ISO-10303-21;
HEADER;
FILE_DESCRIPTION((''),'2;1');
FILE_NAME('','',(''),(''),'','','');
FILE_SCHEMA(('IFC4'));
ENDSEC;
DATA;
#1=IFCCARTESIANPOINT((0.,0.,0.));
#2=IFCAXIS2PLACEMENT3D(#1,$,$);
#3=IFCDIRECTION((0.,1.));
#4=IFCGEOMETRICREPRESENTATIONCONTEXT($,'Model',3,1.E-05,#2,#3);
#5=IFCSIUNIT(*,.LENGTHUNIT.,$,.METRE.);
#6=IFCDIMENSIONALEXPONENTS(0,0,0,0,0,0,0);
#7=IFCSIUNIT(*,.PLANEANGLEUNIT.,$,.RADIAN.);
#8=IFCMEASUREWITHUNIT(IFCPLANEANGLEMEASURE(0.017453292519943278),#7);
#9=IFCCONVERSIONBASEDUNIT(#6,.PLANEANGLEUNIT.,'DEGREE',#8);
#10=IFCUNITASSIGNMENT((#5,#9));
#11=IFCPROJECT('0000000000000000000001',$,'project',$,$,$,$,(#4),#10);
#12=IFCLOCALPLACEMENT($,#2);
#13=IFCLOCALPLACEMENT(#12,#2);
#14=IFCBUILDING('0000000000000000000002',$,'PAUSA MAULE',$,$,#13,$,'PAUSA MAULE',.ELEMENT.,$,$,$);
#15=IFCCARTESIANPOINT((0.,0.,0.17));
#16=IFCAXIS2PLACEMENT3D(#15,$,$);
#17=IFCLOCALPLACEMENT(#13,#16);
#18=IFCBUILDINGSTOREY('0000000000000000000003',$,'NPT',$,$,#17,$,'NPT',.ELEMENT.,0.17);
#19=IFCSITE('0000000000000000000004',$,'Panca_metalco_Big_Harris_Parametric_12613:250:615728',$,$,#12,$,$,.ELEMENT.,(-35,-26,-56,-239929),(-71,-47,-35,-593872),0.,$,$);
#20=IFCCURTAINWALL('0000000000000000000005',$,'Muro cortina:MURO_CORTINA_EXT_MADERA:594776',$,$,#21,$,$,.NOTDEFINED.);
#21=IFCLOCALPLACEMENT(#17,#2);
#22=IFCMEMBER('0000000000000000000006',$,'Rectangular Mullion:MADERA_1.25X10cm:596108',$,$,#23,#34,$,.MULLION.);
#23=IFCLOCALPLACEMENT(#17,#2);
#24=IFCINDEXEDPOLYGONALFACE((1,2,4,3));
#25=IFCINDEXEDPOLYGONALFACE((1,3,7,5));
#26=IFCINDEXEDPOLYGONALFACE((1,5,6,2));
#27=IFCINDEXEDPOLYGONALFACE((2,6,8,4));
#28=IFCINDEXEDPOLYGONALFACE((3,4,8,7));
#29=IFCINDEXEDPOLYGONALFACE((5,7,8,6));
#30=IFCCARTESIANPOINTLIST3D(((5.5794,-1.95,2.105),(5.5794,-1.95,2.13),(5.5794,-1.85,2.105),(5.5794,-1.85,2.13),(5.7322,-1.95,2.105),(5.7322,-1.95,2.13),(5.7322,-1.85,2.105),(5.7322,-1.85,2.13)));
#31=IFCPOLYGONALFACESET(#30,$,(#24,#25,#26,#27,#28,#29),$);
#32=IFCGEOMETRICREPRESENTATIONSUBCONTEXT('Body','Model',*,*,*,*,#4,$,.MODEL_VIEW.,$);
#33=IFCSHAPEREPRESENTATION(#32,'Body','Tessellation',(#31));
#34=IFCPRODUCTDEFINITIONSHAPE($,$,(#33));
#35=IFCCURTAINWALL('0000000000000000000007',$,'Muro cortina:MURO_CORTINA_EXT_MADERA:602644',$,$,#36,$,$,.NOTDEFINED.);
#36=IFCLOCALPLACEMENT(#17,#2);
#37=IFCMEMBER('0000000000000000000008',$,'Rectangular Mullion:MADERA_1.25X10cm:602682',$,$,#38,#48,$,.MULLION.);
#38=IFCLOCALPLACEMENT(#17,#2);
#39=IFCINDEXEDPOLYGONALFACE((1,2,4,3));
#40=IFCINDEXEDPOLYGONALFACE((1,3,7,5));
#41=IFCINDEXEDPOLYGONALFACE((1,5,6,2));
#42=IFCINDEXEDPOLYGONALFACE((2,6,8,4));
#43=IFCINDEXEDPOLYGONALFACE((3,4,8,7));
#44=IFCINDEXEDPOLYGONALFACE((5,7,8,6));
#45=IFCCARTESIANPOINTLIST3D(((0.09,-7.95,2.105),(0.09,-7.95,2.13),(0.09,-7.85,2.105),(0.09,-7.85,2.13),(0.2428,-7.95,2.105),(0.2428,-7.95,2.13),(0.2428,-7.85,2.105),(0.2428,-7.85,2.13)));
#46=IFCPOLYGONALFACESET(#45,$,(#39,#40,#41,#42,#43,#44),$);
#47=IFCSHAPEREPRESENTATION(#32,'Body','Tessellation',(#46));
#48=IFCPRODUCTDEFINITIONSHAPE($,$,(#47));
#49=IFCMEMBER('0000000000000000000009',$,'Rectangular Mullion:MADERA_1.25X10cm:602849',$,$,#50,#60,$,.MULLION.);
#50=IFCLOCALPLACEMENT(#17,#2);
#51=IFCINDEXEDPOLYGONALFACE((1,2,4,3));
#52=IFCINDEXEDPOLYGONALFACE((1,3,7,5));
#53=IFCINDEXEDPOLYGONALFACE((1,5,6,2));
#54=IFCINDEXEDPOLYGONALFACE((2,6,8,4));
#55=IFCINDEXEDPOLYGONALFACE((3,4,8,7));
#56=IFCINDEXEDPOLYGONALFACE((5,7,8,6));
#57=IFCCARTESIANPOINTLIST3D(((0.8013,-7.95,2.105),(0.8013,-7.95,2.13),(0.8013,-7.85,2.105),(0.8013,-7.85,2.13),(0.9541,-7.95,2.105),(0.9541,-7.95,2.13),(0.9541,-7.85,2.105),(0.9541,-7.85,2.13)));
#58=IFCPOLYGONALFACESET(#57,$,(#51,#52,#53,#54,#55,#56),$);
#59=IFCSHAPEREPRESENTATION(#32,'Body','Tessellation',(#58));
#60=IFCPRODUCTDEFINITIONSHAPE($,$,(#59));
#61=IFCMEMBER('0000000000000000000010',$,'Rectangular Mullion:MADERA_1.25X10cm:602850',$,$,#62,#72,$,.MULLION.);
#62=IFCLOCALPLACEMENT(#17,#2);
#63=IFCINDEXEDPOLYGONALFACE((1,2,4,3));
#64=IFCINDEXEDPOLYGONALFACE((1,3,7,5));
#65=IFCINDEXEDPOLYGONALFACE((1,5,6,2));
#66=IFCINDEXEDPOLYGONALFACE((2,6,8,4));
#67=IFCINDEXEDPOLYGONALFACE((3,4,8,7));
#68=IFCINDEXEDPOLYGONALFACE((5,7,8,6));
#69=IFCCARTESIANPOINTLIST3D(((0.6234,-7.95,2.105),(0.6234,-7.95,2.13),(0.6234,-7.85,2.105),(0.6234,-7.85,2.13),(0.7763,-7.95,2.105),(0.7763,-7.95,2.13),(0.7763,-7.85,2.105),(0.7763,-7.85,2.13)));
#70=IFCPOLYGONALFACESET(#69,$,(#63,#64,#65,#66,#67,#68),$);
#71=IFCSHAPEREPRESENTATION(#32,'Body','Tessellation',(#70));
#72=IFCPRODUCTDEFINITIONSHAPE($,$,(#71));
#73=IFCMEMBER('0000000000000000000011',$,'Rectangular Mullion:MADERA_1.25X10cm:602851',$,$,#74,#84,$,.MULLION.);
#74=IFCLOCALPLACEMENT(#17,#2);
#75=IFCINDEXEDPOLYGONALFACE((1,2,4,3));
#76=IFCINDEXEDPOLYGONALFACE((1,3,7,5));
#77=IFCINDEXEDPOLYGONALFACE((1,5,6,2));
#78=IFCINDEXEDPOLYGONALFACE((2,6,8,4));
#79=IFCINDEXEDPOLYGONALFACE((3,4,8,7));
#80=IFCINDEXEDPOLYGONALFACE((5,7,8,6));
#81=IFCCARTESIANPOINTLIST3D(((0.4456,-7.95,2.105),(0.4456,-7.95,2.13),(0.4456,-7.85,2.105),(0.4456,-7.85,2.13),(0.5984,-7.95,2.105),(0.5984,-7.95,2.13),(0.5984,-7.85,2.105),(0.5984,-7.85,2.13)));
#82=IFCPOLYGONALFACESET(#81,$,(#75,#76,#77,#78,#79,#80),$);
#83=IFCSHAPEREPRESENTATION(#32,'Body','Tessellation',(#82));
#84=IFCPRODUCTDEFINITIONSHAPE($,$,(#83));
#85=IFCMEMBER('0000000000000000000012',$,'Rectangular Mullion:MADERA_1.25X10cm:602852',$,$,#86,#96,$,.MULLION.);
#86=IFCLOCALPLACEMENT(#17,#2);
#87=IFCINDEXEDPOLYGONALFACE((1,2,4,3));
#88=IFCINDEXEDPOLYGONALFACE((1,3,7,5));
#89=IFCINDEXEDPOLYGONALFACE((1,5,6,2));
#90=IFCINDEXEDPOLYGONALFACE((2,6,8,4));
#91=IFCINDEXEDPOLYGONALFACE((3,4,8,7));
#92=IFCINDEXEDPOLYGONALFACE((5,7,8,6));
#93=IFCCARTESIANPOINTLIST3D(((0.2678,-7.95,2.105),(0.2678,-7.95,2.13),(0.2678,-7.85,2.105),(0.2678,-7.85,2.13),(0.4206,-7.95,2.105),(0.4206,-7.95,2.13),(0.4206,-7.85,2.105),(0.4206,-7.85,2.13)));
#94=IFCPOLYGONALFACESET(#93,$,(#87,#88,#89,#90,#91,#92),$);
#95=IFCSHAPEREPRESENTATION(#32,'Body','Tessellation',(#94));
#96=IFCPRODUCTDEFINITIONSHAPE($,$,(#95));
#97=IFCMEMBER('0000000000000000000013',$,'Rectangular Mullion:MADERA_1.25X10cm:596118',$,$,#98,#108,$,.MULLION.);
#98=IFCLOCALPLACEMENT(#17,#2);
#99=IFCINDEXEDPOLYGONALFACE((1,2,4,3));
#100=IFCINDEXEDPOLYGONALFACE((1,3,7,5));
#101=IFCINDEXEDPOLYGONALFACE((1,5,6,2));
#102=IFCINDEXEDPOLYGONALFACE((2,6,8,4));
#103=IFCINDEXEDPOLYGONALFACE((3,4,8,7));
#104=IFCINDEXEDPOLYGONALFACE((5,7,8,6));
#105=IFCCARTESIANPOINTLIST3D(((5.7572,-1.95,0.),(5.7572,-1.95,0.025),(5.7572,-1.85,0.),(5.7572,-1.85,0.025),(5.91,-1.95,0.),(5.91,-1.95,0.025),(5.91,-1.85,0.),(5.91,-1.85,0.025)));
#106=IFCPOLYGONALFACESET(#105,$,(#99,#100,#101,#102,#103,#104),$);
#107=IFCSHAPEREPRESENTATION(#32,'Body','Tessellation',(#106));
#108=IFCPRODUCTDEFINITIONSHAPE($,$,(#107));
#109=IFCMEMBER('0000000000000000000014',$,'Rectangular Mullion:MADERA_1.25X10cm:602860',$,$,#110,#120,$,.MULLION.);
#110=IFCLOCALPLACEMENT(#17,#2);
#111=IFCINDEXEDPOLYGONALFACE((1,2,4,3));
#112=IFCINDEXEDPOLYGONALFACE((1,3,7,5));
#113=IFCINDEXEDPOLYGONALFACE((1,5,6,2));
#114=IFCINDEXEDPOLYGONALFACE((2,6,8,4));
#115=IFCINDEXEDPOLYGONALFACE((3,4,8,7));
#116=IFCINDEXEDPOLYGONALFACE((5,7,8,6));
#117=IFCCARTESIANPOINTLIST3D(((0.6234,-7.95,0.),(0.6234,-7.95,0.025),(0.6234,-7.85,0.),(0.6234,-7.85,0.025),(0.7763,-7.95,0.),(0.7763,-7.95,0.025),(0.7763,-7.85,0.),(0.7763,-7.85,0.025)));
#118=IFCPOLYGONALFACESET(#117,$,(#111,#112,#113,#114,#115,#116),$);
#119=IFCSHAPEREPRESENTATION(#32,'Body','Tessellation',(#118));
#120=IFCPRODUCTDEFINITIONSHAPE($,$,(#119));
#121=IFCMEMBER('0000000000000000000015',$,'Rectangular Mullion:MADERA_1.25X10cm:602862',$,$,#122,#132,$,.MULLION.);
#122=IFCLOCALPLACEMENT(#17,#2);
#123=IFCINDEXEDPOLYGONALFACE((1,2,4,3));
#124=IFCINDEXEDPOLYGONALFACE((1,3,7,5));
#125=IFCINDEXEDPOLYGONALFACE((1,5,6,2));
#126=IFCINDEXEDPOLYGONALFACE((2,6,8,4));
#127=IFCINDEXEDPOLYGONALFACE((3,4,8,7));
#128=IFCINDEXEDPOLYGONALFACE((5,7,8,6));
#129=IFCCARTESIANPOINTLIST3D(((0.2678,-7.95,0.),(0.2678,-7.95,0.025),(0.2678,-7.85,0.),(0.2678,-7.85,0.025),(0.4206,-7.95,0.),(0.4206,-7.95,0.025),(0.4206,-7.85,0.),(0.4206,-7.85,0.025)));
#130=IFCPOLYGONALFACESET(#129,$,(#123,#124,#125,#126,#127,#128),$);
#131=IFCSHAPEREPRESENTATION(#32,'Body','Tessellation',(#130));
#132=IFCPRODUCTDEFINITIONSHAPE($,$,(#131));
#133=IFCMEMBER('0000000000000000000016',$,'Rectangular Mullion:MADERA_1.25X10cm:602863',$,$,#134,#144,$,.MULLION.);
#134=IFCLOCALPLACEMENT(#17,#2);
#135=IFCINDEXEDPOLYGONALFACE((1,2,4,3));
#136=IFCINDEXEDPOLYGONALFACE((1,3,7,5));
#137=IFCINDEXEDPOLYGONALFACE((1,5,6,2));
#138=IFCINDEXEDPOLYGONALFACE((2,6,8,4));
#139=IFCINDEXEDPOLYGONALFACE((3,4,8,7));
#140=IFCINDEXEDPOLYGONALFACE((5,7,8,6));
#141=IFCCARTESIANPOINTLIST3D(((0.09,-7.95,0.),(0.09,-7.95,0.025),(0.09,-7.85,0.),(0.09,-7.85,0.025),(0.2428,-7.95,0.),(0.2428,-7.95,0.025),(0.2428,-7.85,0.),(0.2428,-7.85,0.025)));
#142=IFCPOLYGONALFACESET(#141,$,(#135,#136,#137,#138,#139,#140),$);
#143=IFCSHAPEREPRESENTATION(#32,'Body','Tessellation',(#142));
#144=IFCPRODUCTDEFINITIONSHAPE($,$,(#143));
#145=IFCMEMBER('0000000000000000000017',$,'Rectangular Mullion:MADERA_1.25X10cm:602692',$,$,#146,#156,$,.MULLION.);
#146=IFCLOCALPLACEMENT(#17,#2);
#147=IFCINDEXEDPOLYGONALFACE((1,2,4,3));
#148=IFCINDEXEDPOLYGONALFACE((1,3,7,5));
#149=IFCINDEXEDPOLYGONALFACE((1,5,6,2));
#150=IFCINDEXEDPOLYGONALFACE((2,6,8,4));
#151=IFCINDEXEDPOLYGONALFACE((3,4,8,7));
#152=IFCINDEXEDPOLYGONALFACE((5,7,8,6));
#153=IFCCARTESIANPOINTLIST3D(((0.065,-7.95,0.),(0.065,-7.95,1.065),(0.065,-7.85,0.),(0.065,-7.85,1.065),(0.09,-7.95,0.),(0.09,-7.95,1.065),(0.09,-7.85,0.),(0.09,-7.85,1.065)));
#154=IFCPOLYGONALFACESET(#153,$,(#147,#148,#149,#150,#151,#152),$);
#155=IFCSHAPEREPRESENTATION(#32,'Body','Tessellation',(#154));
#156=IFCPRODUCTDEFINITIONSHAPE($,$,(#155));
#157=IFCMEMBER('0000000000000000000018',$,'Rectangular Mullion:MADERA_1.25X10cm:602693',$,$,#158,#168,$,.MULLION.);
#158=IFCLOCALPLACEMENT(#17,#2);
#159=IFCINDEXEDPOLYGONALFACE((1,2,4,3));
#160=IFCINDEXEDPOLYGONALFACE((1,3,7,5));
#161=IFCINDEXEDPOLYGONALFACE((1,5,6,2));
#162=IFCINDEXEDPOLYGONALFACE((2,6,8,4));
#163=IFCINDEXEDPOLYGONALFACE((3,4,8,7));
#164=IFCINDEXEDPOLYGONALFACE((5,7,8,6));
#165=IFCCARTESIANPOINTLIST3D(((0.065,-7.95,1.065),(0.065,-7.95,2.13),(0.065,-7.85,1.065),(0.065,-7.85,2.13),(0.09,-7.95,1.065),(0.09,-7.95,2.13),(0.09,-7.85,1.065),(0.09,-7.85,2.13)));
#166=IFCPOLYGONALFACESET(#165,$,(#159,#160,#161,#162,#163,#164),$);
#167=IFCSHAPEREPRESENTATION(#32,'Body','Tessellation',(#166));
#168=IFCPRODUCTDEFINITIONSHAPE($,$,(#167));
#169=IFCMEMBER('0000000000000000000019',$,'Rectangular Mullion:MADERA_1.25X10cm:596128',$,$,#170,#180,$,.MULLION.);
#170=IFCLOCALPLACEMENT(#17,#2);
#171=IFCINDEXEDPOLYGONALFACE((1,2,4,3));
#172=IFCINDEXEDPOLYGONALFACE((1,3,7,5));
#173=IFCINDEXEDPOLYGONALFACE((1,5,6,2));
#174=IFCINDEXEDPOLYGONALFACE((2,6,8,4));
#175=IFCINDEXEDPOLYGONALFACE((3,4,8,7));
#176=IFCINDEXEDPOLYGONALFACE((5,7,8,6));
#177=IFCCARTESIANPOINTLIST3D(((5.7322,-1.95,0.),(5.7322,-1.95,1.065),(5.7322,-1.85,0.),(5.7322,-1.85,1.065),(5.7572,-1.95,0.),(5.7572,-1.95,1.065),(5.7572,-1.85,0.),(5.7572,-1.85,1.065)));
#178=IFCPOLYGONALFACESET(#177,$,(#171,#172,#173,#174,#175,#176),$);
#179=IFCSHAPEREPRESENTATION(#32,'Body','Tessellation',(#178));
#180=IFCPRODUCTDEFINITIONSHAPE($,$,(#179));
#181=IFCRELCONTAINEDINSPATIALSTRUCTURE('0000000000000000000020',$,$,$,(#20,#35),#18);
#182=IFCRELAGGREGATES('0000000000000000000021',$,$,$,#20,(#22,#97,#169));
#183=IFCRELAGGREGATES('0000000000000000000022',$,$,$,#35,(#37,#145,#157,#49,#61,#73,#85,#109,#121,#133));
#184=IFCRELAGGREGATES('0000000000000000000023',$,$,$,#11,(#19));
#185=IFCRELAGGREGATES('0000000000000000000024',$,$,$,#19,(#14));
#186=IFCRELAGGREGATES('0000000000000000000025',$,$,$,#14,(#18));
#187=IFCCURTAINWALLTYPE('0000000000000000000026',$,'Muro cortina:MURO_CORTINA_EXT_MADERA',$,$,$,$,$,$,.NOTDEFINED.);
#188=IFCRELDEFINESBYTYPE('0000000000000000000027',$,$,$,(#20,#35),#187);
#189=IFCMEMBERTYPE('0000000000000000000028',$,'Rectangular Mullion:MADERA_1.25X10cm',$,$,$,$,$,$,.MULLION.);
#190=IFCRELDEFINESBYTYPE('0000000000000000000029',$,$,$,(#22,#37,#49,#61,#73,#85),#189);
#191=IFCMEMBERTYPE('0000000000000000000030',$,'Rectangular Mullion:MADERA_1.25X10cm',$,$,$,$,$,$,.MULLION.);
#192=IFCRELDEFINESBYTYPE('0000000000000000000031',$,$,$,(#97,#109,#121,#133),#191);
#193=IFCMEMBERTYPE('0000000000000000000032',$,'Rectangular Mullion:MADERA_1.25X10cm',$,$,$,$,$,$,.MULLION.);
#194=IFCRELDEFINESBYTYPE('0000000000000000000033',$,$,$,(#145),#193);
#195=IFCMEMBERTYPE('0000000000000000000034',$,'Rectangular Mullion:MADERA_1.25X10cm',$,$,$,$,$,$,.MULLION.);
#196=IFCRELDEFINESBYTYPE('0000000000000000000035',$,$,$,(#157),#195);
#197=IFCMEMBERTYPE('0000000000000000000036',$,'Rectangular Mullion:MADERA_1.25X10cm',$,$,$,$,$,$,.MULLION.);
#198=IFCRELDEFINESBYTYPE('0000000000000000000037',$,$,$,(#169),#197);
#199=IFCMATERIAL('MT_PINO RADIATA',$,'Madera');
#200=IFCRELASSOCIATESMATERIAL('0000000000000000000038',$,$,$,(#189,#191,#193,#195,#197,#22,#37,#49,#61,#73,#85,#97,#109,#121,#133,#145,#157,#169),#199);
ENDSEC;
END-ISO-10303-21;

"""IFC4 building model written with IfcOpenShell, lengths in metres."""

from ifc_helpers import new_model, entity, si_unit, converted_unit, direction, frame, frame_2d, origin, origin_2d_with_axis, place, context, subcontext, project, spatial, rectangle, extrude, source, transform, mapped, material, material_profile, profile_set, profile_usage, type_object, type_shapes, element, aggregate, save


model = new_model("IFC4")

# Units and contexts
model_context = context("Model", 3, precision=1e-05, world=origin(), true_north=direction((0.0, 1.0)))
body_context = subcontext(model_context, "Body", "Model", "MODEL_VIEW")
ifc_project = project(units=[si_unit("LENGTHUNIT", "METRE"), converted_unit("PLANEANGLEUNIT", "DEGREE", entity("IfcPlaneAngleMeasure", 0.017453292519943278), si_unit("PLANEANGLEUNIT", "RADIAN"), dimensions=[0, 0, 0, 0, 0, 0, 0])], contexts=[model_context])

# Site, building, storey
site_placement = place(None, origin())
site = spatial("IfcSite", under=ifc_project, at=site_placement, Name="Panca_metalco_Big_Harris_Parametric_12613:250:615728", CompositionType="ELEMENT", RefLatitude=(-35, -26, -56, -239929), RefLongitude=(-71, -47, -35, -593872), RefElevation=0.0)
building_placement = place(site_placement, origin())
building = spatial("IfcBuilding", under=site, at=building_placement, Name="PAUSA MAULE", LongName="PAUSA MAULE", CompositionType="ELEMENT")
storey_placement = place(building_placement, frame((0.0, 0.0, 0.17)))
storey = spatial("IfcBuildingStorey", under=building, at=storey_placement, Name="NPT", LongName="NPT", CompositionType="ELEMENT", Elevation=0.17)

# Curtain wall, member
curtain_wall_type = type_object("IfcCurtainWallType", Name="Muro cortina:MURO_CORTINA_EXT_MADERA", PredefinedType="NOTDEFINED")
curtain_wall_1_placement = place(storey_placement, frame((0.0, 0.0, -0.17)))
curtain_wall_1 = element("IfcCurtainWall", 1, at=curtain_wall_1_placement, inside=storey, type_object=curtain_wall_type, Name="Muro cortina:MURO_CORTINA_EXT_MADERA:594776", PredefinedType="NOTDEFINED")
ifc_material_1 = material(Name="MT_PINO RADIATA", Category="Madera")
ifc_material_profile = material_profile(ifc_material_1, rectangle(XDim=0.025, YDim=0.1, at=frame_2d((0.0, 0.0), x_axis=(1.0, 0.0))), Name="MADERA_1.25X10cm")
ifc_profile_set = profile_set([ifc_material_profile], Name="MADERA_1.25X10cm")
ifc_profile_usage = profile_usage(ifc_profile_set)
member_type_1 = type_object("IfcMemberType", Name="Rectangular Mullion:MADERA_1.25X10cm", PredefinedType="MULLION", material=ifc_profile_set)
shared_shape_1 = source(origin(), body_context, "Body", "SweptSolid", [
    extrude(rectangle(XDim=0.025, YDim=0.1, at=frame_2d((0.0, 0.0), x_axis=(1.0, 0.0))), frame((-0.0125, 0.0, -0.1528), z_axis=(0.0, 0.0, 1.0), x_axis=(-1.0, 0.0, 0.0)), (0.0, 0.0, 1.0), 0.1528),
])
type_shapes(member_type_1, [shared_shape_1])
member_1_placement = place(curtain_wall_1_placement, frame((5.7322, -1.9, 2.3), z_axis=(1.0, 0.0, 0.0), x_axis=(0.0, 0.0, 1.0)))
member_1 = element("IfcMember", 2, at=member_1_placement, type_object=member_type_1, material=ifc_profile_usage, Name="Rectangular Mullion:MADERA_1.25X10cm:596108", PredefinedType="MULLION", context=body_context, shape_type="MappedRepresentation", body=[
    mapped(shared_shape_1, transform((0.0, 0.0, 0.0), scale=1.0)),
])

# Curtain wall, members
curtain_wall_2_placement = place(storey_placement, frame((0.0, 0.0, -0.17)))
curtain_wall_2 = element("IfcCurtainWall", 3, at=curtain_wall_2_placement, inside=storey, type_object=curtain_wall_type, Name="Muro cortina:MURO_CORTINA_EXT_MADERA:602644", PredefinedType="NOTDEFINED")
member_2_placement = place(curtain_wall_2_placement, frame((0.09, -7.9, 2.3), z_axis=(-1.0, 0.0, 0.0), x_axis=(0.0, 0.0, 1.0)))
member_2 = element("IfcMember", 4, at=member_2_placement, type_object=member_type_1, material=ifc_profile_usage, Name="Rectangular Mullion:MADERA_1.25X10cm:602682", PredefinedType="MULLION", context=body_context, shape_type="MappedRepresentation", body=[
    mapped(shared_shape_1, transform((0.0, 0.0, 0.0), scale=1.0)),
])
member_3_placement = place(curtain_wall_2_placement, frame((0.8013, -7.9, 2.3), z_axis=(-1.0, 0.0, 0.0), x_axis=(0.0, 0.0, 1.0)))
member_3 = element("IfcMember", 5, at=member_3_placement, type_object=member_type_1, material=ifc_profile_usage, Name="Rectangular Mullion:MADERA_1.25X10cm:602849", PredefinedType="MULLION", context=body_context, shape_type="MappedRepresentation", body=[
    mapped(shared_shape_1, transform((0.0, 0.0, 0.0), scale=1.0)),
])
member_4_placement = place(curtain_wall_2_placement, frame((0.6234, -7.9, 2.3), z_axis=(-1.0, 0.0, 0.0), x_axis=(0.0, 0.0, 1.0)))
member_4 = element("IfcMember", 6, at=member_4_placement, type_object=member_type_1, material=ifc_profile_usage, Name="Rectangular Mullion:MADERA_1.25X10cm:602850", PredefinedType="MULLION", context=body_context, shape_type="MappedRepresentation", body=[
    mapped(shared_shape_1, transform((0.0, 0.0, 0.0), scale=1.0)),
])
member_5_placement = place(curtain_wall_2_placement, frame((0.4456, -7.9, 2.3), z_axis=(-1.0, 0.0, 0.0), x_axis=(0.0, 0.0, 1.0)))
member_5 = element("IfcMember", 7, at=member_5_placement, type_object=member_type_1, material=ifc_profile_usage, Name="Rectangular Mullion:MADERA_1.25X10cm:602851", PredefinedType="MULLION", context=body_context, shape_type="MappedRepresentation", body=[
    mapped(shared_shape_1, transform((0.0, 0.0, 0.0), scale=1.0)),
])
member_6_placement = place(curtain_wall_2_placement, frame((0.2678, -7.9, 2.3), z_axis=(-1.0, 0.0, 0.0), x_axis=(0.0, 0.0, 1.0)))
member_6 = element("IfcMember", 8, at=member_6_placement, type_object=member_type_1, material=ifc_profile_usage, Name="Rectangular Mullion:MADERA_1.25X10cm:602852", PredefinedType="MULLION", context=body_context, shape_type="MappedRepresentation", body=[
    mapped(shared_shape_1, transform((0.0, 0.0, 0.0), scale=1.0)),
])

# Members
member_type_2 = type_object("IfcMemberType", Name="Rectangular Mullion:MADERA_1.25X10cm", PredefinedType="MULLION", material=ifc_profile_set)
shared_shape_2 = source(origin(), body_context, "Body", "SweptSolid", [
    extrude(rectangle(XDim=0.025, YDim=0.1, at=frame_2d((0.0, 0.0), x_axis=(1.0, 0.0))), frame((-0.0125, 0.0, -0.1528), z_axis=(0.0, 0.0, 1.0), x_axis=(-1.0, 0.0, 0.0)), (0.0, 0.0, 1.0), 0.1528),
])
type_shapes(member_type_2, [shared_shape_2])
member_7_placement = place(curtain_wall_1_placement, frame((5.7572, -1.9, 0.17), z_axis=(-1.0, 0.0, 0.0), x_axis=(0.0, 0.0, -1.0)))
member_7 = element("IfcMember", 9, at=member_7_placement, type_object=member_type_2, material=ifc_profile_usage, Name="Rectangular Mullion:MADERA_1.25X10cm:596118", PredefinedType="MULLION", context=body_context, shape_type="MappedRepresentation", body=[
    mapped(shared_shape_2, transform((0.0, 0.0, 0.0), scale=1.0)),
])
member_8_placement = place(curtain_wall_2_placement, frame((0.7763, -7.9, 0.17), z_axis=(1.0, 0.0, 0.0), x_axis=(0.0, 0.0, -1.0)))
member_8 = element("IfcMember", 10, at=member_8_placement, type_object=member_type_2, material=ifc_profile_usage, Name="Rectangular Mullion:MADERA_1.25X10cm:602860", PredefinedType="MULLION", context=body_context, shape_type="MappedRepresentation", body=[
    mapped(shared_shape_2, transform((0.0, 0.0, 0.0), scale=1.0)),
])
member_9_placement = place(curtain_wall_2_placement, frame((0.4206, -7.9, 0.17), z_axis=(1.0, 0.0, 0.0), x_axis=(0.0, 0.0, -1.0)))
member_9 = element("IfcMember", 11, at=member_9_placement, type_object=member_type_2, material=ifc_profile_usage, Name="Rectangular Mullion:MADERA_1.25X10cm:602862", PredefinedType="MULLION", context=body_context, shape_type="MappedRepresentation", body=[
    mapped(shared_shape_2, transform((0.0, 0.0, 0.0), scale=1.0)),
])
member_10_placement = place(curtain_wall_2_placement, frame((0.2428, -7.9, 0.17), z_axis=(1.0, 0.0, 0.0), x_axis=(0.0, 0.0, -1.0)))
member_10 = element("IfcMember", 12, at=member_10_placement, type_object=member_type_2, material=ifc_profile_usage, Name="Rectangular Mullion:MADERA_1.25X10cm:602863", PredefinedType="MULLION", context=body_context, shape_type="MappedRepresentation", body=[
    mapped(shared_shape_2, transform((0.0, 0.0, 0.0), scale=1.0)),
])
member_type_3 = type_object("IfcMemberType", Name="Rectangular Mullion:MADERA_1.25X10cm", PredefinedType="MULLION", material=ifc_profile_set)
shared_shape_3 = source(origin(), body_context, "Body", "SweptSolid", [
    extrude(rectangle(XDim=0.025, YDim=0.1, at=origin_2d_with_axis()), frame((-0.0125, 0.0, -1.065), z_axis=(0.0, 0.0, 1.0), x_axis=(-1.0, 0.0, 0.0)), (0.0, 0.0, 1.0), 1.065),
])
type_shapes(member_type_3, [shared_shape_3])
member_11_placement = place(curtain_wall_2_placement, frame((0.065, -7.9, 0.17), z_axis=(0.0, 0.0, -1.0), x_axis=(-1.0, 0.0, 0.0)))
member_11 = element("IfcMember", 13, at=member_11_placement, type_object=member_type_3, material=ifc_profile_usage, Name="Rectangular Mullion:MADERA_1.25X10cm:602692", PredefinedType="MULLION", context=body_context, shape_type="MappedRepresentation", body=[
    mapped(shared_shape_3, transform((0.0, 0.0, 0.0), scale=1.0)),
])
member_type_4 = type_object("IfcMemberType", Name="Rectangular Mullion:MADERA_1.25X10cm", PredefinedType="MULLION", material=ifc_profile_set)
shared_shape_4 = source(origin(), body_context, "Body", "SweptSolid", [
    extrude(rectangle(XDim=0.025, YDim=0.1, at=origin_2d_with_axis()), frame((-0.0125, 0.0, -1.065), z_axis=(0.0, 0.0, 1.0), x_axis=(-1.0, 0.0, 0.0)), (0.0, 0.0, 1.0), 1.065),
])
type_shapes(member_type_4, [shared_shape_4])
member_12_placement = place(curtain_wall_2_placement, frame((0.065, -7.9, 1.235), z_axis=(0.0, 0.0, -1.0), x_axis=(-1.0, 0.0, 0.0)))
member_12 = element("IfcMember", 14, at=member_12_placement, type_object=member_type_4, material=ifc_profile_usage, Name="Rectangular Mullion:MADERA_1.25X10cm:602693", PredefinedType="MULLION", context=body_context, shape_type="MappedRepresentation", body=[
    mapped(shared_shape_4, transform((0.0, 0.0, 0.0), scale=1.0)),
])
member_type_5 = type_object("IfcMemberType", Name="Rectangular Mullion:MADERA_1.25X10cm", PredefinedType="MULLION", material=ifc_profile_set)
shared_shape_5 = source(origin(), body_context, "Body", "SweptSolid", [
    extrude(rectangle(XDim=0.025, YDim=0.1, at=frame_2d((0.0, 0.0), x_axis=(1.0, 0.0))), frame((0.0, 0.0, -1.065), z_axis=(0.0, 0.0, 1.0), x_axis=(-1.0, 0.0, 0.0)), (0.0, 0.0, 1.0), 1.065),
])
type_shapes(member_type_5, [shared_shape_5])
member_13_placement = place(curtain_wall_1_placement, frame((5.7447, -1.9, 0.17), z_axis=(0.0, 0.0, -1.0), x_axis=(1.0, 0.0, 0.0)))
member_13 = element("IfcMember", 15, at=member_13_placement, type_object=member_type_5, material=ifc_profile_usage, Name="Rectangular Mullion:MADERA_1.25X10cm:596128", PredefinedType="MULLION", context=body_context, shape_type="MappedRepresentation", body=[
    mapped(shared_shape_5, transform((0.0, 0.0, 0.0), scale=1.0)),
])
aggregate(curtain_wall_1, [member_1, member_7, member_13])
aggregate(curtain_wall_2, [member_2, member_11, member_12, member_3, member_4, member_5, member_6, member_8, member_9, member_10])

save(model, "model.ifc")
